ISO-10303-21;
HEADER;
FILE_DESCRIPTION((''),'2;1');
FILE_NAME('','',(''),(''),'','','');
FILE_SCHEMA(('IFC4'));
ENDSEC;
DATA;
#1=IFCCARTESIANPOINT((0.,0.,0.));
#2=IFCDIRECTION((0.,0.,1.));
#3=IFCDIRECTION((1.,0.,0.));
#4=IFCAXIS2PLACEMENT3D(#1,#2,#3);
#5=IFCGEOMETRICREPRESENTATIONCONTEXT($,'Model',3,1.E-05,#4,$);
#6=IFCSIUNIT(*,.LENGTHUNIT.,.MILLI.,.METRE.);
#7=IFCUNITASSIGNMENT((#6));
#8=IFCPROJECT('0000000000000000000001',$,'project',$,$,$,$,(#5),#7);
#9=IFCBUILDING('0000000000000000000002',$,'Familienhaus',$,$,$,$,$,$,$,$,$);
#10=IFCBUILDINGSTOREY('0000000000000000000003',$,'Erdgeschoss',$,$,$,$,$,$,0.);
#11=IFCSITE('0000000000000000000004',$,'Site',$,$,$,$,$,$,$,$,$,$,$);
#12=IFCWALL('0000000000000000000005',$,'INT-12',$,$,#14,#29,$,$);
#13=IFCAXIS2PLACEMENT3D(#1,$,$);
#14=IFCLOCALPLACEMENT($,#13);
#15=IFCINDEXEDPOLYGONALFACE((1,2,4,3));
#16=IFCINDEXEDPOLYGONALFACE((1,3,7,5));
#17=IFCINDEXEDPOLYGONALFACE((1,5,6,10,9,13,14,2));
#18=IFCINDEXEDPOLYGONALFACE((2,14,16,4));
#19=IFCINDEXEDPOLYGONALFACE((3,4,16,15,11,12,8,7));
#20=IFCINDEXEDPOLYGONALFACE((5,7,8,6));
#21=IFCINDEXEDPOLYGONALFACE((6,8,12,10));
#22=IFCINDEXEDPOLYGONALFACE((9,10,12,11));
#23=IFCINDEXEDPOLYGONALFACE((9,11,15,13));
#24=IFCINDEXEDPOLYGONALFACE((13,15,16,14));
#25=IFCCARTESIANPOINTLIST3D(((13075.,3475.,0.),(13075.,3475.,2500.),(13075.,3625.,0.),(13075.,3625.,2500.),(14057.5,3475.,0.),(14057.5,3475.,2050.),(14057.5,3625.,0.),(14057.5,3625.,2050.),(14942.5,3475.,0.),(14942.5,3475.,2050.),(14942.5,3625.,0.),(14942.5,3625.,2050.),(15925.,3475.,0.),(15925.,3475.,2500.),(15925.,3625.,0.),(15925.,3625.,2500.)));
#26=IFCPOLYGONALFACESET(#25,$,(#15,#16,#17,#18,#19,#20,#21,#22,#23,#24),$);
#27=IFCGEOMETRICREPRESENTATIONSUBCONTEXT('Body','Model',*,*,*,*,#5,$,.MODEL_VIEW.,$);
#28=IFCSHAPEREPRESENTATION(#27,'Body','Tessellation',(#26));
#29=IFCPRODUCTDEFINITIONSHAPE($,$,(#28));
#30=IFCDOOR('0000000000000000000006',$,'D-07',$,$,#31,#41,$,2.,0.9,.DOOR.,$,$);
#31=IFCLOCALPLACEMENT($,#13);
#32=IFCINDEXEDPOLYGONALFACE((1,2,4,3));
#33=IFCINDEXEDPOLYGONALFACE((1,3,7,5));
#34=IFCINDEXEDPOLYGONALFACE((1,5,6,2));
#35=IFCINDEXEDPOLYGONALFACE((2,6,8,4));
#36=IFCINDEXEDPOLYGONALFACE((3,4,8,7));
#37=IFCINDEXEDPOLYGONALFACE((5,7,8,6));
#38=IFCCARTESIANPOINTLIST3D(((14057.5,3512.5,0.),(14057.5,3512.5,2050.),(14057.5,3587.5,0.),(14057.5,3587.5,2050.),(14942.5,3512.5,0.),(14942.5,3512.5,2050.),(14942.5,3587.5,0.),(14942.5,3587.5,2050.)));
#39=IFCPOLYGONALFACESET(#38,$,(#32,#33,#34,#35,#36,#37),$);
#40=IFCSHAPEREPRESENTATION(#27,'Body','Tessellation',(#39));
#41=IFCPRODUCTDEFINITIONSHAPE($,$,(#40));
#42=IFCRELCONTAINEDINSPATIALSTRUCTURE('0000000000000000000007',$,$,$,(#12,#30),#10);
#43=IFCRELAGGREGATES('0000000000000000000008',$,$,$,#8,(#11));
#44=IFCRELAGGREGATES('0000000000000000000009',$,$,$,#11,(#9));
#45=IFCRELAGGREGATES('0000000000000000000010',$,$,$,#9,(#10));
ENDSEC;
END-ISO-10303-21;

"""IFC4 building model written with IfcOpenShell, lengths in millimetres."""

from ifc_helpers import new_model, si_unit, origin_with_axes, place, context, subcontext, project, spatial, indexed_curve, outline, extrude, element, fill, save


model = new_model("IFC4")

# Units and contexts
model_context = context("Model", 3, precision=1e-05, world=origin_with_axes())
body_context = subcontext(model_context, "Body", "Model", "MODEL_VIEW")
ifc_project = project(units=[si_unit("LENGTHUNIT", "METRE", prefix="MILLI")], contexts=[model_context])

# Site, building, storey
site = spatial("IfcSite", under=ifc_project, Name="Site")
building = spatial("IfcBuilding", under=site, Name="Familienhaus")
storey = spatial("IfcBuildingStorey", under=building, Name="Erdgeschoss", Elevation=0.0)

# Wall, opening, door
wall_1_placement = place(None, origin_with_axes())
wall_1 = element("IfcWall", 1, at=wall_1_placement, inside=storey, Name="INT-12", context=body_context, shape_type="SweptSolid", body=[
    extrude(outline(indexed_curve([(13075.0, 3625.0), (15925.0, 3625.0), (15925.0, 3475.0), (13075.0, 3475.0), (13075.0, 3625.0)])), origin_with_axes(), (0.0, 0.0, 1.0), 2500.0),
])
opening_1_placement = place(wall_1_placement, origin_with_axes())
opening_1 = element("IfcOpeningElement", 2, at=opening_1_placement, cuts=wall_1, context=body_context, shape_type="SweptSolid", body=[
    extrude(outline(indexed_curve([(14057.5, 3645.0), (14942.5, 3645.0), (14942.5, 3455.0), (14057.5, 3455.0), (14057.5, 3645.0)])), origin_with_axes(), (0.0, 0.0, 1.0), 2050.0),
])
door_1_placement = place(opening_1_placement, origin_with_axes())
door_1 = element("IfcDoor", 3, at=door_1_placement, inside=storey, Name="D-07", OverallHeight=2.0, OverallWidth=0.9, PredefinedType="DOOR", context=body_context, shape_type="SweptSolid", body=[
    extrude(outline(indexed_curve([(14057.5, 3587.5), (14942.5, 3587.5), (14942.5, 3512.5), (14057.5, 3512.5), (14057.5, 3587.5)])), origin_with_axes(), (0.0, 0.0, 1.0), 2050.0),
])
fill(opening_1, door_1)

save(model, "model.ifc")
